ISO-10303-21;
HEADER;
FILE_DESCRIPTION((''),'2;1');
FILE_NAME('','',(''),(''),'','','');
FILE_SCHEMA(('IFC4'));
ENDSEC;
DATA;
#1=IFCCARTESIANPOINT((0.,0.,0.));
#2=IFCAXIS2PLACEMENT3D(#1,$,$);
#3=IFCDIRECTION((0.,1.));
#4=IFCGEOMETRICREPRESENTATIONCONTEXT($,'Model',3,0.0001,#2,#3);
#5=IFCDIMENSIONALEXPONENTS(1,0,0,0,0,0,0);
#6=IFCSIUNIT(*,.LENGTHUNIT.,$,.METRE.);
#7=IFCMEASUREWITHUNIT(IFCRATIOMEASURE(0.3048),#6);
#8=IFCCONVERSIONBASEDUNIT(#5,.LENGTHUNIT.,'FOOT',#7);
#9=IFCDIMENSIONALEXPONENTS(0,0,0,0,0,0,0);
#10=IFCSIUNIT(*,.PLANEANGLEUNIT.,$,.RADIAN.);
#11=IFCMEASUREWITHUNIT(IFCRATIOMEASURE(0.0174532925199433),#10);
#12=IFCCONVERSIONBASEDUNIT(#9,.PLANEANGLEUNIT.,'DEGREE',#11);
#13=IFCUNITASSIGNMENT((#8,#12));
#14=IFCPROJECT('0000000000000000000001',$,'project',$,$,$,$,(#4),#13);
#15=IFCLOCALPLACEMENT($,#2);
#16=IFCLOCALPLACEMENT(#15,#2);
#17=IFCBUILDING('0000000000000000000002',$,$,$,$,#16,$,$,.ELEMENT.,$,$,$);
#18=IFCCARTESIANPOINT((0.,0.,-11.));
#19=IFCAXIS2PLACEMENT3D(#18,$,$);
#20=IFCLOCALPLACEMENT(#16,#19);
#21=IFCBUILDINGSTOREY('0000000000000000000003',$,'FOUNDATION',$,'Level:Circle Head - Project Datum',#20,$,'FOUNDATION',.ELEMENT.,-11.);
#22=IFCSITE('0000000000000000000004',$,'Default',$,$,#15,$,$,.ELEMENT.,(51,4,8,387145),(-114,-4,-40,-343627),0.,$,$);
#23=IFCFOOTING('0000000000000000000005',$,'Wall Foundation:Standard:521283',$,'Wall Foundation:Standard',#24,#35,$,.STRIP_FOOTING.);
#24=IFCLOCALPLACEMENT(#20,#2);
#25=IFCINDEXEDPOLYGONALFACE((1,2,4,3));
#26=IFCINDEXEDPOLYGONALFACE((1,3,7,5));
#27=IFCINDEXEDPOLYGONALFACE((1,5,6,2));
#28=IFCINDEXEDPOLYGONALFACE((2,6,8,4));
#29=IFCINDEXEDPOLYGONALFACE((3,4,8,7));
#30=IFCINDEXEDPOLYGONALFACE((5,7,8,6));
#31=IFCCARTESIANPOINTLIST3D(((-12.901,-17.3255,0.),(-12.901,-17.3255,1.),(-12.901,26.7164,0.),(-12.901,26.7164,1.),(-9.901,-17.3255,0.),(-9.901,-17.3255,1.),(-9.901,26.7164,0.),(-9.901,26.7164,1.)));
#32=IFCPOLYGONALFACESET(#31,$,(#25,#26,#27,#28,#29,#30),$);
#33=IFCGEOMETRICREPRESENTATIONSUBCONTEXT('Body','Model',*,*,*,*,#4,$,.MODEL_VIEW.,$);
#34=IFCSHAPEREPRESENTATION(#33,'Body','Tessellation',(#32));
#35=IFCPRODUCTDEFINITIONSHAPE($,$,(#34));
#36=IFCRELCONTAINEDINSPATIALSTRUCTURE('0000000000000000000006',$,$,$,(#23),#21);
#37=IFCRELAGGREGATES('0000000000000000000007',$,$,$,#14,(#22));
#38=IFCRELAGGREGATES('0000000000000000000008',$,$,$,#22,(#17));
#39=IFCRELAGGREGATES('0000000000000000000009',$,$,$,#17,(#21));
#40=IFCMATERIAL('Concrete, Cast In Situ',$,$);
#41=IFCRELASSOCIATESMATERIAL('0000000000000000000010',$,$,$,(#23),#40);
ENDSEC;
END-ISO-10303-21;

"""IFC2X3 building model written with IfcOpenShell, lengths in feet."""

from ifc_helpers import new_model, entity, si_unit, converted_unit, direction, frame, origin, origin_2d_with_axis, place, context, subcontext, project, spatial, rectangle, extrude, material, element, save


model = new_model("IFC2X3")

# Units and contexts
model_context = context("Model", 3, precision=0.0001, world=origin(), true_north=direction((0.0, 1.0)))
body_context = subcontext(model_context, "Body", "Model", "MODEL_VIEW")
ifc_project = project(units=[converted_unit("LENGTHUNIT", "FOOT", entity("IfcRatioMeasure", 0.3048), si_unit("LENGTHUNIT", "METRE"), dimensions=[1, 0, 0, 0, 0, 0, 0]), converted_unit("PLANEANGLEUNIT", "DEGREE", entity("IfcRatioMeasure", 0.0174532925199433), si_unit("PLANEANGLEUNIT", "RADIAN"), dimensions=[0, 0, 0, 0, 0, 0, 0])], contexts=[model_context])

# Site, building, storey
site_placement = place(None, origin())
site = spatial("IfcSite", under=ifc_project, at=site_placement, Name="Default", CompositionType="ELEMENT", RefLatitude=(51, 4, 8, 387145), RefLongitude=(-114, -4, -40, -343627), RefElevation=0.0)
building_placement = place(site_placement, origin())
building = spatial("IfcBuilding", under=site, at=building_placement, CompositionType="ELEMENT")
storey_placement = place(building_placement, frame((0.0, 0.0, -11.0)))
storey = spatial("IfcBuildingStorey", under=building, at=storey_placement, Name="FOUNDATION", ObjectType="Level:Circle Head - Project Datum", LongName="FOUNDATION", CompositionType="ELEMENT", Elevation=-11.0)

# Footing
ifc_material = material(Name="Concrete, Cast In Situ")
footing_1_placement = place(storey_placement, origin())
element("IfcFooting", 1, at=footing_1_placement, inside=storey, material=ifc_material, Name="Wall Foundation:Standard:521283", ObjectType="Wall Foundation:Standard", PredefinedType="STRIP_FOOTING", context=body_context, shape_type="SweptSolid", body=[
    extrude(rectangle(XDim=44.0418, YDim=3.0, at=origin_2d_with_axis()), frame((-11.401, 4.6955, 0.0), z_axis=(0.0, 0.0, 1.0), x_axis=(0.0, 1.0, 0.0)), (0.0, 0.0, 1.0), 1.0),
])

save(model, "model.ifc")
